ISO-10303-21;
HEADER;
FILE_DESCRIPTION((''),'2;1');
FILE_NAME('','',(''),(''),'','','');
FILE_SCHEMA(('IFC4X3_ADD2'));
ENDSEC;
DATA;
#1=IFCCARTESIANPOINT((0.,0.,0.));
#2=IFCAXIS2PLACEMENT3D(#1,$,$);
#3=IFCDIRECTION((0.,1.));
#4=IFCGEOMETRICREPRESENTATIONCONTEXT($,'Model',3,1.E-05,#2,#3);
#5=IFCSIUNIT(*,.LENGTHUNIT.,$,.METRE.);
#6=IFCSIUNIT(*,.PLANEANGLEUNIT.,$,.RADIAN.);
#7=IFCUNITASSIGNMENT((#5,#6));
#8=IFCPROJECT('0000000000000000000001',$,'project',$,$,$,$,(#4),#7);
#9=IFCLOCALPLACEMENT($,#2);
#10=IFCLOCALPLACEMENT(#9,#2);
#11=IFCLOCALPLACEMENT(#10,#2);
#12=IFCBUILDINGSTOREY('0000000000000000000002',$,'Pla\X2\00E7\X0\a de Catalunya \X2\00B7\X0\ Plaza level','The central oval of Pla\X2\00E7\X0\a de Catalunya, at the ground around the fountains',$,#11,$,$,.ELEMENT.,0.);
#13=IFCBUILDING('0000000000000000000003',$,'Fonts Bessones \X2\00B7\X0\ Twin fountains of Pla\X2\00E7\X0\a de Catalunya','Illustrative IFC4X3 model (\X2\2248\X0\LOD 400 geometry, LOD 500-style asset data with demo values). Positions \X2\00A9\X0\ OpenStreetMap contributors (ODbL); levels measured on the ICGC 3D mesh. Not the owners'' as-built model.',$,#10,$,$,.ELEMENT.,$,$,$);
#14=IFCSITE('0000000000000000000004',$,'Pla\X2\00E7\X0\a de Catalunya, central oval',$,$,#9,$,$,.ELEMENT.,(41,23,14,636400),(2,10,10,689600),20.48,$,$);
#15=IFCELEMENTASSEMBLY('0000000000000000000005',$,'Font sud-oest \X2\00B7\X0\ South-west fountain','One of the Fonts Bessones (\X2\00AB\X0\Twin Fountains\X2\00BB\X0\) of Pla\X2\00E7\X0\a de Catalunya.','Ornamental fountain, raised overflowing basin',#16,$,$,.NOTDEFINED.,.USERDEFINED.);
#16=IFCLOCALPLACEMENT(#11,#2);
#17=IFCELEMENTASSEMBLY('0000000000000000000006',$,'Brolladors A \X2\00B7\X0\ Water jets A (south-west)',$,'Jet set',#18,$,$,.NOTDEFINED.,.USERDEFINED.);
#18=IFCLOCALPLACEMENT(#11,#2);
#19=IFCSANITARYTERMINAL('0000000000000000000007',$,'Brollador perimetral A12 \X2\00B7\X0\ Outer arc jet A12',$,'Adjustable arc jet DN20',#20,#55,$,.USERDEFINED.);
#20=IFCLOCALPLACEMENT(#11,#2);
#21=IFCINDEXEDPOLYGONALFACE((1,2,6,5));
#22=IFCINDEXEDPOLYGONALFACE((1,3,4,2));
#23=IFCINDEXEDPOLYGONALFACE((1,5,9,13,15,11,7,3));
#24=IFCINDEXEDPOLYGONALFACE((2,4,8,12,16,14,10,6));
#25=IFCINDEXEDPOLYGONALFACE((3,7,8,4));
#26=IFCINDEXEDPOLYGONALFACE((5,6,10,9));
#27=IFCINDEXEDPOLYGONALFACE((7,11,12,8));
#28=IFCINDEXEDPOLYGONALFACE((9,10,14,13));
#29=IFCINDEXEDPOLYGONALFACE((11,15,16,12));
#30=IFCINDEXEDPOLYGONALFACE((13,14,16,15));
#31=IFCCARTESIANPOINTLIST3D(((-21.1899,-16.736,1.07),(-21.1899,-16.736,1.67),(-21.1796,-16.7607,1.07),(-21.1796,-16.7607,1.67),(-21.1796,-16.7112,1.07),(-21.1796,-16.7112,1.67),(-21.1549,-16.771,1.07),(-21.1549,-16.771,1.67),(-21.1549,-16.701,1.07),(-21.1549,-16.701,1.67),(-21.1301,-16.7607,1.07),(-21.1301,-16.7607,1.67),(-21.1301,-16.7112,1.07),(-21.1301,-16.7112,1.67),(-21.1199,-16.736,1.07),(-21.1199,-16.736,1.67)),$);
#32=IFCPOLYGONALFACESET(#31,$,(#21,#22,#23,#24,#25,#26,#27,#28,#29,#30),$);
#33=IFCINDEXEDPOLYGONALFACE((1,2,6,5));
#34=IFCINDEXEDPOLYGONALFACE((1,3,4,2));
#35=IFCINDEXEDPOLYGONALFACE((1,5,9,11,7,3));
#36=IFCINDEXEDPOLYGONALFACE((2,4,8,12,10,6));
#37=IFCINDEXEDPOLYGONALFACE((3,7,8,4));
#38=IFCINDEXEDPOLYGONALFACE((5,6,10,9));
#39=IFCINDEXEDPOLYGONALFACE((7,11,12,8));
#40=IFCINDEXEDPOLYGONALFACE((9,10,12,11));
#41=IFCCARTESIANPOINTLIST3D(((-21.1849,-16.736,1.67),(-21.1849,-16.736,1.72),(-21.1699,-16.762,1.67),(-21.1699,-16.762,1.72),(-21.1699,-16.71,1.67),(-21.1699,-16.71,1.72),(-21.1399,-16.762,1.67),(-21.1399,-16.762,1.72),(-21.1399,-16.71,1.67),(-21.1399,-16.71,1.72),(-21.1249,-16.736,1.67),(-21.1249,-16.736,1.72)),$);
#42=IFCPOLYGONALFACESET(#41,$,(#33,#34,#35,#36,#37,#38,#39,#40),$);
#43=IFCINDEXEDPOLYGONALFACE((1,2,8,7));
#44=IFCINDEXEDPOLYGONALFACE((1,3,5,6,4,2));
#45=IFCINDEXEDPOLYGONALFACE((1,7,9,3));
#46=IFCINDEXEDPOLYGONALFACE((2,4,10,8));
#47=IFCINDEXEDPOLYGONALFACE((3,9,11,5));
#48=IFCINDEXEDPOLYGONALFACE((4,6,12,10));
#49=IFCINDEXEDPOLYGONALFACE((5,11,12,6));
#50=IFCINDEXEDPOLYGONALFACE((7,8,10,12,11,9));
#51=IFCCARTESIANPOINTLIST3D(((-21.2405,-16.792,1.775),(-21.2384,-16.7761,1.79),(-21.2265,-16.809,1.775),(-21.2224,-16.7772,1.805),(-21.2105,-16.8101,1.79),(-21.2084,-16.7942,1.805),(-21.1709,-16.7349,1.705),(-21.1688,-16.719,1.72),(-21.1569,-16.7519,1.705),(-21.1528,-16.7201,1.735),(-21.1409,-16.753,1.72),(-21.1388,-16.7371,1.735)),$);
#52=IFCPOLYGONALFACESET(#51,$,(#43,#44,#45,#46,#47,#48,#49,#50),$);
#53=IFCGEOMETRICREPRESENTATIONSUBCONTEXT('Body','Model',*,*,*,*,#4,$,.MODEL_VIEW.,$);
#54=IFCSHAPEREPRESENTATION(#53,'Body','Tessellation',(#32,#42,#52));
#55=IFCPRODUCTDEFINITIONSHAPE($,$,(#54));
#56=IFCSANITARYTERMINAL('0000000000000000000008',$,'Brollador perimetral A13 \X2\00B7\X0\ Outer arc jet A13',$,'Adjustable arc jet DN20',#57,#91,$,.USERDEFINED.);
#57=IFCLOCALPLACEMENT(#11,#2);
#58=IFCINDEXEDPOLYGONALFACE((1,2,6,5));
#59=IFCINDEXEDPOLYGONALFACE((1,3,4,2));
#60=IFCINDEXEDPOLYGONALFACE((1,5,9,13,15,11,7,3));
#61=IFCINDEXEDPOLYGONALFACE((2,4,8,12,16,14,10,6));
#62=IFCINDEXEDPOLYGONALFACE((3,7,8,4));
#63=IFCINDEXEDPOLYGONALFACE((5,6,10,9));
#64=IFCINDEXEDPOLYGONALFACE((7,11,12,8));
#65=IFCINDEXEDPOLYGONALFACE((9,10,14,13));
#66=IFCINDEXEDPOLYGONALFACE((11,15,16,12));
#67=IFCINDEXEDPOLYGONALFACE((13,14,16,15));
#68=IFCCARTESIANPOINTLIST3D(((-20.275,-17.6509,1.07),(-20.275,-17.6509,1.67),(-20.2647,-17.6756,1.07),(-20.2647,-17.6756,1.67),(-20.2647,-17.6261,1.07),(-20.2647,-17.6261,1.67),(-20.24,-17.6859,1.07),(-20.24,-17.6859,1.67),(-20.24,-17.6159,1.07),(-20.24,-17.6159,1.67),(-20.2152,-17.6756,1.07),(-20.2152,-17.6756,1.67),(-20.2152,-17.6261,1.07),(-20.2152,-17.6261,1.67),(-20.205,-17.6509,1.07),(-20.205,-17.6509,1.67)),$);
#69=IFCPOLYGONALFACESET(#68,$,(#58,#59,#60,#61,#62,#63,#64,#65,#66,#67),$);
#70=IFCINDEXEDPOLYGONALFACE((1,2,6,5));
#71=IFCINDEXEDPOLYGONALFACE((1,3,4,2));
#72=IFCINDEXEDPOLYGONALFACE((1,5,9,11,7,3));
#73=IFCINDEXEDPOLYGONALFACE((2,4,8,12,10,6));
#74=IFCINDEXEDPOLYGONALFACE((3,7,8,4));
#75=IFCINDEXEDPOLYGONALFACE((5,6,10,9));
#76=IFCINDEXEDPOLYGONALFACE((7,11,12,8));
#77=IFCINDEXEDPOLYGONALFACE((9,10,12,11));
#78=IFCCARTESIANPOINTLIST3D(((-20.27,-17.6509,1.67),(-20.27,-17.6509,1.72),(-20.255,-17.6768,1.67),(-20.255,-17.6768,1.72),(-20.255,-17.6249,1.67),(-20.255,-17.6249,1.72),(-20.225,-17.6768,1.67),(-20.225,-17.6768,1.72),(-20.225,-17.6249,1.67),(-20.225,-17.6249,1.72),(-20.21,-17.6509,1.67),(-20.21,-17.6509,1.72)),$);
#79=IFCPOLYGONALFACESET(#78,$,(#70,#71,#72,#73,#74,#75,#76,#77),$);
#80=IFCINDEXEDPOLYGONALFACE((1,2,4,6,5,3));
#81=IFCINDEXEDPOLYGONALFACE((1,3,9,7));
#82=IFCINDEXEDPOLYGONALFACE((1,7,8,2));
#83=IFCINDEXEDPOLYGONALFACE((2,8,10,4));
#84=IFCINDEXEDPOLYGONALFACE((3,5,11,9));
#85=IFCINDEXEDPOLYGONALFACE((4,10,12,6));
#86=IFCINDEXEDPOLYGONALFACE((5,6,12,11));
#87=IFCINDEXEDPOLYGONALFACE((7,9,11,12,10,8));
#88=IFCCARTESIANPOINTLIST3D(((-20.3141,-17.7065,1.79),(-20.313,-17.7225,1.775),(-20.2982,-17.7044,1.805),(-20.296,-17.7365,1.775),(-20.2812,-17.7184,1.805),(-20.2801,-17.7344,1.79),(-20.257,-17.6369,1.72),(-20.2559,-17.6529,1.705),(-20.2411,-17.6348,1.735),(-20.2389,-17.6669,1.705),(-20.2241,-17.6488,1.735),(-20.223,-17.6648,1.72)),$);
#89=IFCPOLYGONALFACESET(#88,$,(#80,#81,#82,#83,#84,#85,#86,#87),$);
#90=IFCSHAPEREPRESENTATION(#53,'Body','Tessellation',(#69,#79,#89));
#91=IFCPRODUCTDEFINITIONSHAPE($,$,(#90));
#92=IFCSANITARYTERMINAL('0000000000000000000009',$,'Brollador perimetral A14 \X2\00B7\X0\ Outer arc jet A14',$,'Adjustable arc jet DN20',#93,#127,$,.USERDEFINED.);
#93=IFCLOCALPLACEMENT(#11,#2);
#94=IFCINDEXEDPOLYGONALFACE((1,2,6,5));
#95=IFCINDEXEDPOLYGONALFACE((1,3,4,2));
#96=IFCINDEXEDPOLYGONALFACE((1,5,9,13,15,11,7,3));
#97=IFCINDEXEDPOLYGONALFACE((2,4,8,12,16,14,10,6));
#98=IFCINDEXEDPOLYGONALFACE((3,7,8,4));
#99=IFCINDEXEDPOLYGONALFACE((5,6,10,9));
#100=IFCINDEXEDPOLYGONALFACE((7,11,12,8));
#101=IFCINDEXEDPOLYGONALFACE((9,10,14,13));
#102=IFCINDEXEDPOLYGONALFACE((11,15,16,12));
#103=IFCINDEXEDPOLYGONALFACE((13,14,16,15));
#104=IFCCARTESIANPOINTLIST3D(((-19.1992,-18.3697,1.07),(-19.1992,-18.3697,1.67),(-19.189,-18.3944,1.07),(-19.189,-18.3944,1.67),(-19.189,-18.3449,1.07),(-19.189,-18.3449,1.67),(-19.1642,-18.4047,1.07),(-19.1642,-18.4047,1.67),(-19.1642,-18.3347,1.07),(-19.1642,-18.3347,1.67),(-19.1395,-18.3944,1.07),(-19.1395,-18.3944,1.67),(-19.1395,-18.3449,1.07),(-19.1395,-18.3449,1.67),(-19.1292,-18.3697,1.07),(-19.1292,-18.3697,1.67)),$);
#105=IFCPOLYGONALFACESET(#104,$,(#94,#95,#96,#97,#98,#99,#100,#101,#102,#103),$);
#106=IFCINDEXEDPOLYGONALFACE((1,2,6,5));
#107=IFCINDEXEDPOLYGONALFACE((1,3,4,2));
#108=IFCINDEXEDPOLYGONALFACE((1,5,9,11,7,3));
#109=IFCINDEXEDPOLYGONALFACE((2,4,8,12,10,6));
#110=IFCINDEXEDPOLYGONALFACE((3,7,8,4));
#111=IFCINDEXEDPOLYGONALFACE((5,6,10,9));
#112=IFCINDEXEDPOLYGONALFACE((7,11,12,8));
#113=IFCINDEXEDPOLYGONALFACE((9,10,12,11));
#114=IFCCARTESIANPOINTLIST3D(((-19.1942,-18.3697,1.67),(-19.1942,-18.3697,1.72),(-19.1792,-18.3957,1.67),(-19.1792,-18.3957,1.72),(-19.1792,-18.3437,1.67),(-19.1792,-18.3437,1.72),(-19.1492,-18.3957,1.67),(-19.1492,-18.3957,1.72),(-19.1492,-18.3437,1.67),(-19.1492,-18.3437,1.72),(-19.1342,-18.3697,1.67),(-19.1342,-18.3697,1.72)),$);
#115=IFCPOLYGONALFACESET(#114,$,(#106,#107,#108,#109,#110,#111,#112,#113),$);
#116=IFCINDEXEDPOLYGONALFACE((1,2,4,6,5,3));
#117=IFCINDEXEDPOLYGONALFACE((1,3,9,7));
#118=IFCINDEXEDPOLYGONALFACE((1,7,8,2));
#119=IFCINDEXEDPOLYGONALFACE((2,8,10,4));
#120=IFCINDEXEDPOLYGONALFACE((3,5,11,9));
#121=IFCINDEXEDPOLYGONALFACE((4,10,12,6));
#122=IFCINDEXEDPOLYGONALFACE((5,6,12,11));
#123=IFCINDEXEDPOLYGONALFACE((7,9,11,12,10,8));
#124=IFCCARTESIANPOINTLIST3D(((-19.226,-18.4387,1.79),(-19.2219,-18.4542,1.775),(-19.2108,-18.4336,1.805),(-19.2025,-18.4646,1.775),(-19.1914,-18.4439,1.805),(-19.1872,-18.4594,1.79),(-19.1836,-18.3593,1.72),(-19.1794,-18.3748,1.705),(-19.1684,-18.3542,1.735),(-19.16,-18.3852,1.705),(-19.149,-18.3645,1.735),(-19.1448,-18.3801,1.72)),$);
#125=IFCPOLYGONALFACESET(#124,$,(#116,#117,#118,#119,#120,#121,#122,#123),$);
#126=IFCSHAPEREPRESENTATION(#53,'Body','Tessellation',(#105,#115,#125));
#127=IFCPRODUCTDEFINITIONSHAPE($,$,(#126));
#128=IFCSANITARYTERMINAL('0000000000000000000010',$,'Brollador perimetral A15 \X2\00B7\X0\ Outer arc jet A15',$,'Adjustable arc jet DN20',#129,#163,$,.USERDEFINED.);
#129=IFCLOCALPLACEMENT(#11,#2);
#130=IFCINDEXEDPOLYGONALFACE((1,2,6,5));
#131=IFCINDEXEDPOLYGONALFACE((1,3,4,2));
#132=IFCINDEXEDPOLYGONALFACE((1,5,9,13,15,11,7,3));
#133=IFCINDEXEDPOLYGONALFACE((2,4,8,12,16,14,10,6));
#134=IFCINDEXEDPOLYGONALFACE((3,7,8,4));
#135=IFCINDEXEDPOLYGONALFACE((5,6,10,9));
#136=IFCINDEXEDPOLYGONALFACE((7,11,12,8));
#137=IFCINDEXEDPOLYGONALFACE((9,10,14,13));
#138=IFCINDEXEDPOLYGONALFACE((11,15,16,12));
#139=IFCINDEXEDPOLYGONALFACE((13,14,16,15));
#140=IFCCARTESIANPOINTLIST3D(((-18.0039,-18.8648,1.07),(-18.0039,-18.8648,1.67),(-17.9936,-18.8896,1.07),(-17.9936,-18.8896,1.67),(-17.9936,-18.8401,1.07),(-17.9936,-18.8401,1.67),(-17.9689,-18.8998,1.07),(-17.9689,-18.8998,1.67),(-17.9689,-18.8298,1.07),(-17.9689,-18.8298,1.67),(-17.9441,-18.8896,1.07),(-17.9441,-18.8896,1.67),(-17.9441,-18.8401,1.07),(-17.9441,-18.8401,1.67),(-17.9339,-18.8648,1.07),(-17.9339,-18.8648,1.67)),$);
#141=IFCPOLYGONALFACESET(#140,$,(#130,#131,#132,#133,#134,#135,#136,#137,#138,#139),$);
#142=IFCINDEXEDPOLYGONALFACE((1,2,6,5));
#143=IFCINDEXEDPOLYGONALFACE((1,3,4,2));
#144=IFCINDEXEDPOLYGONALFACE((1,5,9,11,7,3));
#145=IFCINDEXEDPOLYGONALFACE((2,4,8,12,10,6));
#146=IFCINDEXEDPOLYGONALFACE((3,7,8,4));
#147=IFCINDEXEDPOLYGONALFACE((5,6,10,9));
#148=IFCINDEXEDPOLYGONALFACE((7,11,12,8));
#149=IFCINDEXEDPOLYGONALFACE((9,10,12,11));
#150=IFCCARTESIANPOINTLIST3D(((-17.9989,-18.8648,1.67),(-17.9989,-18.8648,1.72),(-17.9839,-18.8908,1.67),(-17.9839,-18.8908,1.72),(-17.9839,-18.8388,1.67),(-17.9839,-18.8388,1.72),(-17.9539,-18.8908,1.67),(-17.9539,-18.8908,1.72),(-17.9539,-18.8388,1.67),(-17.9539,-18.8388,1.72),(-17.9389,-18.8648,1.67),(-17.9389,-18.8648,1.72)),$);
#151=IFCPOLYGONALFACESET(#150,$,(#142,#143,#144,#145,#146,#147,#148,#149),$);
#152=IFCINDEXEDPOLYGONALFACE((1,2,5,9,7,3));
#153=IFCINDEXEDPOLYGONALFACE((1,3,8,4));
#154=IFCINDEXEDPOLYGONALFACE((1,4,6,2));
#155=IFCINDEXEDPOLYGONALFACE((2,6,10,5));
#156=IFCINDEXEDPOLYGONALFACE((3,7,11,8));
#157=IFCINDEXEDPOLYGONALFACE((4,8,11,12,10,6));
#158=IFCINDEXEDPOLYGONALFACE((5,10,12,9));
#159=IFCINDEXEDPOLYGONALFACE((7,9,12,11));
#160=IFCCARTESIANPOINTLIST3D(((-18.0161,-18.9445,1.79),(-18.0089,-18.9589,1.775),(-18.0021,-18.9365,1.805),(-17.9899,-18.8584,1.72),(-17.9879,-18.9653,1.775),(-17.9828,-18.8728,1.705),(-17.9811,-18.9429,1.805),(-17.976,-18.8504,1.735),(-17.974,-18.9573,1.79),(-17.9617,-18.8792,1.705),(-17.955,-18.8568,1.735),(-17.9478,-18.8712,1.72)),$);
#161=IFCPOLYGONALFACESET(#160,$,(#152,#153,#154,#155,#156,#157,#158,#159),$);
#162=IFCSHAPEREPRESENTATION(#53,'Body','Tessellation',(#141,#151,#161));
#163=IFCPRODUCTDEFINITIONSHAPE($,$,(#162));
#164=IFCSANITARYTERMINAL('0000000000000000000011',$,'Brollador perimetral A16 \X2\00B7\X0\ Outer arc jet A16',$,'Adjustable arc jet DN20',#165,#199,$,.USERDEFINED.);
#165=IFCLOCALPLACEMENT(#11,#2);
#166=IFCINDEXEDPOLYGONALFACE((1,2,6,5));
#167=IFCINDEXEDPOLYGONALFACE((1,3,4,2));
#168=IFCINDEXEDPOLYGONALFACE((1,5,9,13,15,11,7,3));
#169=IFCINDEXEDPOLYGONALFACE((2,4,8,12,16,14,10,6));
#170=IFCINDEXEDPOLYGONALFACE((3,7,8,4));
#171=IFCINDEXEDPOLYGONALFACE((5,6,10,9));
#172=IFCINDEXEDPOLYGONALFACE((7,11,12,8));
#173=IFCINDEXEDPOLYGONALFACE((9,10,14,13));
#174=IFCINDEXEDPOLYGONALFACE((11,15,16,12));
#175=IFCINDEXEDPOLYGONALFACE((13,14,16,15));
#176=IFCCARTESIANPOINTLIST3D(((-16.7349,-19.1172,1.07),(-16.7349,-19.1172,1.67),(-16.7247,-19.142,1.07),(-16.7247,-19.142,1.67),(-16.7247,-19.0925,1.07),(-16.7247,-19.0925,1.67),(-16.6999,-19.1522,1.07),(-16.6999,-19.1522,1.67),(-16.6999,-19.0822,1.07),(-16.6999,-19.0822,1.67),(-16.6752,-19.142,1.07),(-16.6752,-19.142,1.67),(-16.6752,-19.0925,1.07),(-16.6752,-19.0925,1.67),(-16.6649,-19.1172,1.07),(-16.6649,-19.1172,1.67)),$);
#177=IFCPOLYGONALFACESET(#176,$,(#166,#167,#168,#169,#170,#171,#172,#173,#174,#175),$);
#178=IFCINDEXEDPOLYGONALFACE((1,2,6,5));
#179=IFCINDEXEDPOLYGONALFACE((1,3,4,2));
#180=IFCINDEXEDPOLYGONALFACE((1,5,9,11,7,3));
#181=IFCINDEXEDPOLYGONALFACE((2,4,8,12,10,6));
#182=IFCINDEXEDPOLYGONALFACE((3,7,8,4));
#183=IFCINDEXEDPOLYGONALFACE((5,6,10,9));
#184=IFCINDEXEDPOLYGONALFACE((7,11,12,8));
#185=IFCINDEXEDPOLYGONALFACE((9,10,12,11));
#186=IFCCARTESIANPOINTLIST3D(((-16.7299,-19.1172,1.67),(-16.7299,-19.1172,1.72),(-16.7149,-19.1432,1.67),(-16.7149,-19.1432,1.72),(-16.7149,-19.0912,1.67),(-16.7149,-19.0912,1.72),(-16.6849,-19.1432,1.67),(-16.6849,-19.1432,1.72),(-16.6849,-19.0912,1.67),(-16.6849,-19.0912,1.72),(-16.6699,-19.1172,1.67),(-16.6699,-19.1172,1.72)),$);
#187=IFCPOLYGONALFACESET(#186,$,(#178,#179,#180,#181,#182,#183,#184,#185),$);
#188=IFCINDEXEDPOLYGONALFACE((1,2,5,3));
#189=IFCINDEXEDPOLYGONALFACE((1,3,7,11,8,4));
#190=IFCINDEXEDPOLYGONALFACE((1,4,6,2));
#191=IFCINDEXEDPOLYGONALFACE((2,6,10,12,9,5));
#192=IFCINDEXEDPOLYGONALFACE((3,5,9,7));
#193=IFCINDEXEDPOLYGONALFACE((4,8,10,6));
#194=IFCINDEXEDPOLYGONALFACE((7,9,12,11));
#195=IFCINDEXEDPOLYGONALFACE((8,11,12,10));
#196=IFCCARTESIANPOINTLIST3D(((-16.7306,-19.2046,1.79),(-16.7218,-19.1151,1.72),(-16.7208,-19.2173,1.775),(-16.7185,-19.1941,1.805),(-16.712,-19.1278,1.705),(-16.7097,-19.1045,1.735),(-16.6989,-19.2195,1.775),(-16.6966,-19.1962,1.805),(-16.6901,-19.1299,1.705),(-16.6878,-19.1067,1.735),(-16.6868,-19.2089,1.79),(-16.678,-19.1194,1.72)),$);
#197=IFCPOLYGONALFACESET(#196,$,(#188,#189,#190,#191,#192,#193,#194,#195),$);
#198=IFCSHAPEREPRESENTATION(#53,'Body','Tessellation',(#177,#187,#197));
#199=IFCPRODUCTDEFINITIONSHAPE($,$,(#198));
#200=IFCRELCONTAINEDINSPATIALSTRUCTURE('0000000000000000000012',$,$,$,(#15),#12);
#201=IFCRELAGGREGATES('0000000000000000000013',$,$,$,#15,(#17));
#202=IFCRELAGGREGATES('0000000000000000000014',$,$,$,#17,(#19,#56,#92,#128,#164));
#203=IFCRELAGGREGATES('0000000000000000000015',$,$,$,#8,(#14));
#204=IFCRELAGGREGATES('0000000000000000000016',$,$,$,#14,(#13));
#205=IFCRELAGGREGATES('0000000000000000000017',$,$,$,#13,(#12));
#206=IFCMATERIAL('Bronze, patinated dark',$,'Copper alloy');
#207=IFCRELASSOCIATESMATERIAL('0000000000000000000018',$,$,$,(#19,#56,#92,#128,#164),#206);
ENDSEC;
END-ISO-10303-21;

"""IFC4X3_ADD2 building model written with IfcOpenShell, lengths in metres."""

from ifc_helpers import new_model, si_unit, direction, frame, origin, place, context, subcontext, project, spatial, polyline, outline, extrude, material, element, aggregate, save


model = new_model("IFC4X3_ADD2")

# Units and contexts
model_context = context("Model", 3, precision=1e-05, world=origin(), true_north=direction((0.0, 1.0)))
body_context = subcontext(model_context, "Body", "Model", "MODEL_VIEW")
ifc_project = project(units=[si_unit("LENGTHUNIT", "METRE"), si_unit("PLANEANGLEUNIT", "RADIAN")], contexts=[model_context])

# Site, building, storey
site_placement = place(None, origin())
site = spatial("IfcSite", under=ifc_project, at=site_placement, Name="Plaça de Catalunya, central oval", CompositionType="ELEMENT", RefLatitude=(41, 23, 14, 636400), RefLongitude=(2, 10, 10, 689600), RefElevation=20.48)
building_placement = place(site_placement, origin())
building = spatial("IfcBuilding", under=site, at=building_placement, Name="Fonts Bessones · Twin fountains of Plaça de Catalunya", Description="Illustrative IFC4X3 model (≈LOD 400 geometry, LOD 500-style asset data with demo values). Positions © OpenStreetMap contributors (ODbL); levels measured on the ICGC 3D mesh. Not the owners' as-built model.", CompositionType="ELEMENT")
storey_placement = place(building_placement, origin())
storey = spatial("IfcBuildingStorey", under=building, at=storey_placement, Name="Plaça de Catalunya · Plaza level", Description="The central oval of Plaça de Catalunya, at the ground around the fountains", CompositionType="ELEMENT", Elevation=0.0)

# Element assemblies, sanitary terminals
assembly_1_placement = place(building_placement, origin())
assembly_1 = element("IfcElementAssembly", 1, at=assembly_1_placement, inside=storey, Name="Font sud-oest · South-west fountain", Description="One of the Fonts Bessones («Twin Fountains») of Plaça de Catalunya.", ObjectType="Ornamental fountain, raised overflowing basin", AssemblyPlace="NOTDEFINED", PredefinedType="USERDEFINED")
assembly_2_placement = place(building_placement, origin())
assembly_2 = element("IfcElementAssembly", 2, at=assembly_2_placement, Name="Brolladors A · Water jets A (south-west)", ObjectType="Jet set", AssemblyPlace="NOTDEFINED", PredefinedType="USERDEFINED")
aggregate(assembly_1, [assembly_2])
ifc_material = material(Name="Bronze, patinated dark", Category="Copper alloy")
sanitary_terminal_1_placement = place(building_placement, origin())
sanitary_terminal_1 = element("IfcSanitaryTerminal", 3, at=sanitary_terminal_1_placement, material=ifc_material, Name="Brollador perimetral A12 · Outer arc jet A12", ObjectType="Adjustable arc jet DN20", PredefinedType="USERDEFINED", context=body_context, shape_type="SweptSolid", body=[
    extrude(outline(polyline([(-21.1199, -16.736), (-21.1301, -16.7112), (-21.1549, -16.701), (-21.1796, -16.7112), (-21.1899, -16.736), (-21.1796, -16.7607), (-21.1549, -16.771), (-21.1301, -16.7607), (-21.1199, -16.736)])), frame((0.0, 0.0, 1.07)), (0.0, 0.0, 1.0), 0.6),
    extrude(outline(polyline([(-21.1249, -16.736), (-21.1399, -16.71), (-21.1699, -16.71), (-21.1849, -16.736), (-21.1699, -16.762), (-21.1399, -16.762), (-21.1249, -16.736)])), frame((0.0, 0.0, 1.67)), (0.0, 0.0, 1.0), 0.05),
    extrude(outline(polyline([(0.022, 0.0), (0.011, 0.0191), (-0.011, 0.0191), (-0.022, 0.0), (-0.011, -0.0191), (0.011, -0.0191), (0.022, 0.0)])), frame((-21.1549, -16.736, 1.72), z_axis=(-0.610178, -0.50076, 0.613941), x_axis=(-0.634393, 0.77301, 0.0)), (0.0, 0.0, 1.0), 0.114),
])
sanitary_terminal_2_placement = place(building_placement, origin())
sanitary_terminal_2 = element("IfcSanitaryTerminal", 4, at=sanitary_terminal_2_placement, material=ifc_material, Name="Brollador perimetral A13 · Outer arc jet A13", ObjectType="Adjustable arc jet DN20", PredefinedType="USERDEFINED", context=body_context, shape_type="SweptSolid", body=[
    extrude(outline(polyline([(-20.205, -17.6509), (-20.2152, -17.6261), (-20.24, -17.6159), (-20.2647, -17.6261), (-20.275, -17.6509), (-20.2647, -17.6756), (-20.24, -17.6859), (-20.2152, -17.6756), (-20.205, -17.6509)])), frame((0.0, 0.0, 1.07)), (0.0, 0.0, 1.0), 0.6),
    extrude(outline(polyline([(-20.21, -17.6509), (-20.225, -17.6249), (-20.255, -17.6249), (-20.27, -17.6509), (-20.255, -17.6768), (-20.225, -17.6768), (-20.21, -17.6509)])), frame((0.0, 0.0, 1.67)), (0.0, 0.0, 1.0), 0.05),
    extrude(outline(polyline([(0.022, 0.0), (0.011, 0.0191), (-0.011, 0.0191), (-0.022, 0.0), (-0.011, -0.0191), (0.011, -0.0191), (0.022, 0.0)])), frame((-20.24, -17.6509, 1.72), z_axis=(-0.50076, -0.610178, 0.613941), x_axis=(-0.77301, 0.634393, 0.0)), (0.0, 0.0, 1.0), 0.114),
])
sanitary_terminal_3_placement = place(building_placement, origin())
sanitary_terminal_3 = element("IfcSanitaryTerminal", 5, at=sanitary_terminal_3_placement, material=ifc_material, Name="Brollador perimetral A14 · Outer arc jet A14", ObjectType="Adjustable arc jet DN20", PredefinedType="USERDEFINED", context=body_context, shape_type="SweptSolid", body=[
    extrude(outline(polyline([(-19.1292, -18.3697), (-19.1395, -18.3449), (-19.1642, -18.3347), (-19.189, -18.3449), (-19.1992, -18.3697), (-19.189, -18.3944), (-19.1642, -18.4047), (-19.1395, -18.3944), (-19.1292, -18.3697)])), frame((0.0, 0.0, 1.07)), (0.0, 0.0, 1.0), 0.6),
    extrude(outline(polyline([(-19.1342, -18.3697), (-19.1492, -18.3437), (-19.1792, -18.3437), (-19.1942, -18.3697), (-19.1792, -18.3957), (-19.1492, -18.3957), (-19.1342, -18.3697)])), frame((0.0, 0.0, 1.67)), (0.0, 0.0, 1.0), 0.05),
    extrude(outline(polyline([(0.022, 0.0), (0.011, 0.0191), (-0.011, 0.0191), (-0.022, 0.0), (-0.011, -0.0191), (0.011, -0.0191), (0.022, 0.0)])), frame((-19.1642, -18.3697, 1.72), z_axis=(-0.372098, -0.696147, 0.613941), x_axis=(-0.881921, 0.471397, 0.0)), (0.0, 0.0, 1.0), 0.114),
])
sanitary_terminal_4_placement = place(building_placement, origin())
sanitary_terminal_4 = element("IfcSanitaryTerminal", 6, at=sanitary_terminal_4_placement, material=ifc_material, Name="Brollador perimetral A15 · Outer arc jet A15", ObjectType="Adjustable arc jet DN20", PredefinedType="USERDEFINED", context=body_context, shape_type="SweptSolid", body=[
    extrude(outline(polyline([(-17.9339, -18.8648), (-17.9441, -18.8401), (-17.9689, -18.8298), (-17.9936, -18.8401), (-18.0039, -18.8648), (-17.9936, -18.8896), (-17.9689, -18.8998), (-17.9441, -18.8896), (-17.9339, -18.8648)])), frame((0.0, 0.0, 1.07)), (0.0, 0.0, 1.0), 0.6),
    extrude(outline(polyline([(-17.9389, -18.8648), (-17.9539, -18.8388), (-17.9839, -18.8388), (-17.9989, -18.8648), (-17.9839, -18.8908), (-17.9539, -18.8908), (-17.9389, -18.8648)])), frame((0.0, 0.0, 1.67)), (0.0, 0.0, 1.0), 0.05),
    extrude(outline(polyline([(0.022, 0.0), (0.011, 0.0191), (-0.011, 0.0191), (-0.022, 0.0), (-0.011, -0.0191), (0.011, -0.0191), (0.022, 0.0)])), frame((-17.9689, -18.8648, 1.72), z_axis=(-0.229137, -0.755363, 0.613941), x_axis=(-0.95694, 0.290285, 0.0)), (0.0, 0.0, 1.0), 0.114),
])
sanitary_terminal_5_placement = place(building_placement, origin())
sanitary_terminal_5 = element("IfcSanitaryTerminal", 7, at=sanitary_terminal_5_placement, material=ifc_material, Name="Brollador perimetral A16 · Outer arc jet A16", ObjectType="Adjustable arc jet DN20", PredefinedType="USERDEFINED", context=body_context, shape_type="SweptSolid", body=[
    extrude(outline(polyline([(-16.6649, -19.1172), (-16.6752, -19.0925), (-16.6999, -19.0822), (-16.7247, -19.0925), (-16.7349, -19.1172), (-16.7247, -19.142), (-16.6999, -19.1522), (-16.6752, -19.142), (-16.6649, -19.1172)])), frame((0.0, 0.0, 1.07)), (0.0, 0.0, 1.0), 0.6),
    extrude(outline(polyline([(-16.6699, -19.1172), (-16.6849, -19.0912), (-16.7149, -19.0912), (-16.7299, -19.1172), (-16.7149, -19.1432), (-16.6849, -19.1432), (-16.6699, -19.1172)])), frame((0.0, 0.0, 1.67)), (0.0, 0.0, 1.0), 0.05),
    extrude(outline(polyline([(0.022, 0.0), (0.011, 0.0191), (-0.011, 0.0191), (-0.022, 0.0), (-0.011, -0.0191), (0.011, -0.0191), (0.022, 0.0)])), frame((-16.6999, -19.1172, 1.72), z_axis=(-0.07737, -0.785551, 0.613941), x_axis=(-0.995185, 0.098017, 0.0)), (0.0, 0.0, 1.0), 0.114),
])
aggregate(assembly_2, [sanitary_terminal_1, sanitary_terminal_2, sanitary_terminal_3, sanitary_terminal_4, sanitary_terminal_5])

save(model, "model.ifc")
